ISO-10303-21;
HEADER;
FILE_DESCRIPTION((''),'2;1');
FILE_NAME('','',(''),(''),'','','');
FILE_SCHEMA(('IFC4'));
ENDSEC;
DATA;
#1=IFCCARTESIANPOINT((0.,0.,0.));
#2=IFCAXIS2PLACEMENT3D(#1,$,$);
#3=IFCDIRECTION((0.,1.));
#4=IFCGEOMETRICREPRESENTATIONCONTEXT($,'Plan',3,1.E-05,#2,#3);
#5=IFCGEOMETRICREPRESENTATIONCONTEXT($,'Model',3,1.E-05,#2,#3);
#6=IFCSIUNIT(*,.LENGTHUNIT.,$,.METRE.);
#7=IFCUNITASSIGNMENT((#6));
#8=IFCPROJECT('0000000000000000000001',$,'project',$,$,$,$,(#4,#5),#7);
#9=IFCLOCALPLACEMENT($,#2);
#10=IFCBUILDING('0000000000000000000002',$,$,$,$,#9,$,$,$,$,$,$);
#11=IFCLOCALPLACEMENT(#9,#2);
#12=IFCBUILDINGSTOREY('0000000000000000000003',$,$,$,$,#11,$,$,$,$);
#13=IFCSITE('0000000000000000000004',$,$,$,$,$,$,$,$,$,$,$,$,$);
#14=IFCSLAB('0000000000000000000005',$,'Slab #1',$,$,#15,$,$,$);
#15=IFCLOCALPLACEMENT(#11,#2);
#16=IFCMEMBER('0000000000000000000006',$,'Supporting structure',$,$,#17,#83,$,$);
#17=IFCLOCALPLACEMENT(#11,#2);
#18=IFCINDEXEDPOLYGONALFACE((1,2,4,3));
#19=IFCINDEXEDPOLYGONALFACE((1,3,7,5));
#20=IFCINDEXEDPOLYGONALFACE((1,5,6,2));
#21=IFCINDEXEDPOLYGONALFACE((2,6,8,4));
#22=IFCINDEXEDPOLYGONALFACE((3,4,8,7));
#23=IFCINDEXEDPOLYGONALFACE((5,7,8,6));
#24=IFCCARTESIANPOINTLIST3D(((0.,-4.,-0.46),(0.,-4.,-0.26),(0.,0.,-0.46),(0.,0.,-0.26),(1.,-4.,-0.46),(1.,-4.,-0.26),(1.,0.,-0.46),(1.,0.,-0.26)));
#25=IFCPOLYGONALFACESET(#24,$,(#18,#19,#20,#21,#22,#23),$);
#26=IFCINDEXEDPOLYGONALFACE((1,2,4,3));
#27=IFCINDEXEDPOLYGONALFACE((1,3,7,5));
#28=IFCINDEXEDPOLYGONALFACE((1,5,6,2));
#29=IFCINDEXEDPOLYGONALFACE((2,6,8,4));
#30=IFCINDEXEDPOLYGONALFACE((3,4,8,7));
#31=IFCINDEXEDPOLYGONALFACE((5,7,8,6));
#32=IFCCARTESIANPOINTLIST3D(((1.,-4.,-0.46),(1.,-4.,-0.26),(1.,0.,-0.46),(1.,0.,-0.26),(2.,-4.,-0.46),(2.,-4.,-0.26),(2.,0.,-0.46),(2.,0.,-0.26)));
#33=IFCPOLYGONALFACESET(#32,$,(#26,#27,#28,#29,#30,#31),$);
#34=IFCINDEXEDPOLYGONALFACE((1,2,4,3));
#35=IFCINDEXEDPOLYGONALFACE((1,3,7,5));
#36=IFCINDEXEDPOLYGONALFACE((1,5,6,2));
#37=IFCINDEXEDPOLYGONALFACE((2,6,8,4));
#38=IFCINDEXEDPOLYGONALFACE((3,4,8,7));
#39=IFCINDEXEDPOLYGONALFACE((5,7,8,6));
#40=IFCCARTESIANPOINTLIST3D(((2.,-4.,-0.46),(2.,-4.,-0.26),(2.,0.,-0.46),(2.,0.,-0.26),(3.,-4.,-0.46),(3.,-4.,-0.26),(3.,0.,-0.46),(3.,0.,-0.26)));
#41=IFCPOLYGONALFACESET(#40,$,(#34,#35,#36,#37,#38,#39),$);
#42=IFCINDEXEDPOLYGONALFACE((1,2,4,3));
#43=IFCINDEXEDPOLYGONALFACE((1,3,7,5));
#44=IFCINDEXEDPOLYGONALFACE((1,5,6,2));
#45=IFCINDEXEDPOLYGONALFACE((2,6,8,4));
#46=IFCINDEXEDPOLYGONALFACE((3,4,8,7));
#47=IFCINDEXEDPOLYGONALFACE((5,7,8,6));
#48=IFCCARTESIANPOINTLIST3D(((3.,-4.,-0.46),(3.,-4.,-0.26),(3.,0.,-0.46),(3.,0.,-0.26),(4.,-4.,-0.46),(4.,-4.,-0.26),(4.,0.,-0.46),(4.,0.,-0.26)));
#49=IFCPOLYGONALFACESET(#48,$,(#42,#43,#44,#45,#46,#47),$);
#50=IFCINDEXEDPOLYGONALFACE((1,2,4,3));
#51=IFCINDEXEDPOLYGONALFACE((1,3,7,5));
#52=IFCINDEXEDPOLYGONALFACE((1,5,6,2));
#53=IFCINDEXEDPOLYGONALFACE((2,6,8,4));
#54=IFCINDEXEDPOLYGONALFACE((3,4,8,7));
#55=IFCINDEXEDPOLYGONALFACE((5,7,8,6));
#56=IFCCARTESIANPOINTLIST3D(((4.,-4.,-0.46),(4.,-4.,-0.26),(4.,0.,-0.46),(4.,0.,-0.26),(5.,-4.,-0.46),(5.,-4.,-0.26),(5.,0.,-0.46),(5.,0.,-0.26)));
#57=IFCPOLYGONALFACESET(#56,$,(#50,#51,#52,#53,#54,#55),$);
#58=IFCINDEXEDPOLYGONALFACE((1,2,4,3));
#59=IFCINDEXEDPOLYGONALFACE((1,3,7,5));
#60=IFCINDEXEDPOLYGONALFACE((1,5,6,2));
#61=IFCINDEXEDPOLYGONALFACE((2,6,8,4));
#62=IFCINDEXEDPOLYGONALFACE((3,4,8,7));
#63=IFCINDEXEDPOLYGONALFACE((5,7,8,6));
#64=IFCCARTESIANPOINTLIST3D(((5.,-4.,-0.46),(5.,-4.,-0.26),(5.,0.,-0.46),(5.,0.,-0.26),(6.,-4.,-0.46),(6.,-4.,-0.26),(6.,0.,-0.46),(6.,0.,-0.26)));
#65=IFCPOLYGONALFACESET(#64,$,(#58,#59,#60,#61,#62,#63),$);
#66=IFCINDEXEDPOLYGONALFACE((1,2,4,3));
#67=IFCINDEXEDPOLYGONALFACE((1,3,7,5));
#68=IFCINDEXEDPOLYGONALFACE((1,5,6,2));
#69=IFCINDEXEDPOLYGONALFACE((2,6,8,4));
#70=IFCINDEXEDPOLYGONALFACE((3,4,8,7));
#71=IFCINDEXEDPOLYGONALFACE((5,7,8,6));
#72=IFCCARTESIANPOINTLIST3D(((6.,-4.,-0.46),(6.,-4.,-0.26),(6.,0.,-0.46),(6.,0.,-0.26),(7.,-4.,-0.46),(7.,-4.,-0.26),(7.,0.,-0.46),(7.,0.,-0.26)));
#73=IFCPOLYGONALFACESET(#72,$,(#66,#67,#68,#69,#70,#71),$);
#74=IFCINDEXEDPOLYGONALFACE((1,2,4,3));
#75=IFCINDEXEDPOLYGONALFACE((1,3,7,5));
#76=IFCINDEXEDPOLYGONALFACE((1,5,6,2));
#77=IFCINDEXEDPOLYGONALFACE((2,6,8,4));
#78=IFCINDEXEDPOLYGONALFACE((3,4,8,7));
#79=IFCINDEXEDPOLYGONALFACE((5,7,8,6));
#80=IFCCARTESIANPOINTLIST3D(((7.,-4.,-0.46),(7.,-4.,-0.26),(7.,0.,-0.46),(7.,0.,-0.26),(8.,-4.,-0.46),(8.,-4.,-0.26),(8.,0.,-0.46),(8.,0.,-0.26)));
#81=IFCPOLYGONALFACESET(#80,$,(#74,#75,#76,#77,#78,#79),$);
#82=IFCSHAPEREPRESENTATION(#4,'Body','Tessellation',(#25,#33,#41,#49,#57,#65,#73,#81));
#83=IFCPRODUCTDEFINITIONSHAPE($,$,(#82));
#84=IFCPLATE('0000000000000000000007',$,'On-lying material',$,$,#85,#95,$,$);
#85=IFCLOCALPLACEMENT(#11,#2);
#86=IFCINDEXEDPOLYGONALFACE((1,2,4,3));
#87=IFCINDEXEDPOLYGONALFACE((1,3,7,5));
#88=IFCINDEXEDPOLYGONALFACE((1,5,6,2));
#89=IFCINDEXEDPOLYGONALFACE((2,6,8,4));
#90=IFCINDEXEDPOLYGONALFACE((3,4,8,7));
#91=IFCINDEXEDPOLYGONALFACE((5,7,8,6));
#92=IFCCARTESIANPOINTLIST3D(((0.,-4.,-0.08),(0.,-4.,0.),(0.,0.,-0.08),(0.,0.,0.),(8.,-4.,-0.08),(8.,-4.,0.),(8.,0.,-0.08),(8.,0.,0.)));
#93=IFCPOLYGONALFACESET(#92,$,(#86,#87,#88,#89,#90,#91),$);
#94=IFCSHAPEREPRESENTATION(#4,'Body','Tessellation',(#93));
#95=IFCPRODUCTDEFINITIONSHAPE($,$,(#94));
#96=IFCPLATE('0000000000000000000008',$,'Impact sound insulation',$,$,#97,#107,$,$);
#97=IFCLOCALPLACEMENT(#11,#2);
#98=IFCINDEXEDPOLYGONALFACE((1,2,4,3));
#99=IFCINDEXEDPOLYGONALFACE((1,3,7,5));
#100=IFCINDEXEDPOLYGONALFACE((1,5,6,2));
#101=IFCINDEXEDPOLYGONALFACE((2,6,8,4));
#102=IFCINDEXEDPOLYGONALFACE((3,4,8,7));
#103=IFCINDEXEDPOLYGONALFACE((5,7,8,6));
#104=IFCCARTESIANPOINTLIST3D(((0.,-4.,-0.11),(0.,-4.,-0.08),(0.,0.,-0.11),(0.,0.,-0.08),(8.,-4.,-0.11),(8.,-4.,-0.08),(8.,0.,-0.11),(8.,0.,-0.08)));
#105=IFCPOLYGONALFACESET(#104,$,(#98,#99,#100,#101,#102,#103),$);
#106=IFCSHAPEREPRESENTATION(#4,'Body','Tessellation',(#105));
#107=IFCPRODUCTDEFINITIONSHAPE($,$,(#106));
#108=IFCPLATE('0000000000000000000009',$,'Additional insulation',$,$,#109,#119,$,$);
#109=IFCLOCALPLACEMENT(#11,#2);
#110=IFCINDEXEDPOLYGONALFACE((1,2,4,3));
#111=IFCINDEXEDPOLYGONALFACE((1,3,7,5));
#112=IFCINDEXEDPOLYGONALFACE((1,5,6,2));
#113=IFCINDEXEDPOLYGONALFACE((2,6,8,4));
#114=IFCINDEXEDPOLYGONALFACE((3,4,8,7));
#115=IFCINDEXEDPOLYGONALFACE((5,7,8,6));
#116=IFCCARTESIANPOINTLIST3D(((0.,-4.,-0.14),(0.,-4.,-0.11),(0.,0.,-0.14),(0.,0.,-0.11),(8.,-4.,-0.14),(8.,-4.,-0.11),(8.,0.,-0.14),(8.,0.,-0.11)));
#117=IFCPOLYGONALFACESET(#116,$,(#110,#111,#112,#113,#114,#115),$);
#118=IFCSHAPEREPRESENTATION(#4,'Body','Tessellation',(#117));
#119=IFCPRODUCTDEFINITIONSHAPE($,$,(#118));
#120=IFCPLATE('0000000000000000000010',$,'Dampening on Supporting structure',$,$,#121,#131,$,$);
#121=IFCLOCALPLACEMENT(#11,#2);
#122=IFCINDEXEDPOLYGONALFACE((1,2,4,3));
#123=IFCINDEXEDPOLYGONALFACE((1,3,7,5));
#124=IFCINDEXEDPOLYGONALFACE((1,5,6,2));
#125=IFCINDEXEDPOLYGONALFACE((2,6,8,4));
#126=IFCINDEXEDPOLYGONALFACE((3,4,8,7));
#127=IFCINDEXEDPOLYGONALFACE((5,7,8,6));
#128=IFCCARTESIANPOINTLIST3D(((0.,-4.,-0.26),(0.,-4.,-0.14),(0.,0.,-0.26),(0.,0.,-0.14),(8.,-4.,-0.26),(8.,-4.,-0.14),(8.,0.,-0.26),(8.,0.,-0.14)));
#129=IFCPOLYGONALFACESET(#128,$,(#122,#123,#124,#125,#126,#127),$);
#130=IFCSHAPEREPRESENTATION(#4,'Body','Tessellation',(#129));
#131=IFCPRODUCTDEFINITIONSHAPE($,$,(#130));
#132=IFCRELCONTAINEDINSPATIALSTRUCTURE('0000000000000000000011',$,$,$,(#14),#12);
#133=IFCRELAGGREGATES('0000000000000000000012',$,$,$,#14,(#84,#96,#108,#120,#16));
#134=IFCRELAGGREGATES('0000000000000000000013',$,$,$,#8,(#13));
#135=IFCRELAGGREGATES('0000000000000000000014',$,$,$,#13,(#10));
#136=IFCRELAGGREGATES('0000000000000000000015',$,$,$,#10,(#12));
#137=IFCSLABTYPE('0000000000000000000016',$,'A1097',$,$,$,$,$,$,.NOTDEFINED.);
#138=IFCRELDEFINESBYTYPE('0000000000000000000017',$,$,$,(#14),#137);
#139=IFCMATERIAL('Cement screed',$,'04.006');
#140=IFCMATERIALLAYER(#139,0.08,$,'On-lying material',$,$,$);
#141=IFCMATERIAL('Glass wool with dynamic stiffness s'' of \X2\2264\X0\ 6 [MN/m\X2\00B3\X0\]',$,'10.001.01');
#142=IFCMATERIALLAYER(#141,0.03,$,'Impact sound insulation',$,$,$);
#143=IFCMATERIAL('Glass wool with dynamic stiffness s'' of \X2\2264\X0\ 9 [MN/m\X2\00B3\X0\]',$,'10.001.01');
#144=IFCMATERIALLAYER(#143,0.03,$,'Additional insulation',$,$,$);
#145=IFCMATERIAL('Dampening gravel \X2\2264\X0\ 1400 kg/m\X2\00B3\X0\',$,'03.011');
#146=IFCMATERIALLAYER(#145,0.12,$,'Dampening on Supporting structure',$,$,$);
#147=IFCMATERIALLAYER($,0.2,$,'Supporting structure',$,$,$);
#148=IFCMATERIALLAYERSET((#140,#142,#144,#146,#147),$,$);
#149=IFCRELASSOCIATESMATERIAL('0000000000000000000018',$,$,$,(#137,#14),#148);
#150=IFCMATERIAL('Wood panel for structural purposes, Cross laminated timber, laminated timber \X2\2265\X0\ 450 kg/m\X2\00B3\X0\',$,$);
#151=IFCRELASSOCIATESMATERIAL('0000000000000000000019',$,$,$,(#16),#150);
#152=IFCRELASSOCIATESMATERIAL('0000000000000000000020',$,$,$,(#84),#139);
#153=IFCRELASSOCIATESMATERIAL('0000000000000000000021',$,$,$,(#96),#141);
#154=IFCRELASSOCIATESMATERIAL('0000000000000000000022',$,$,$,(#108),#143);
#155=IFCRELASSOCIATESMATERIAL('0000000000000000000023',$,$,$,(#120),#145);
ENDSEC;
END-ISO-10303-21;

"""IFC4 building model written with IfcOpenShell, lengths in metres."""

from ifc_helpers import new_model, si_unit, direction, frame, frame_2d, origin, origin_with_axes, place, context, project, spatial, rectangle, extrude, material, layer, layer_set, type_object, element, aggregate, save


model = new_model("IFC4")

# Units and contexts
plan_context = context("Plan", 3, precision=1e-05, world=origin(), true_north=direction((0.0, 1.0)))
model_context = context("Model", 3, precision=1e-05, world=origin(), true_north=direction((0.0, 1.0)))
ifc_project = project(units=[si_unit("LENGTHUNIT", "METRE")], contexts=[plan_context, model_context])

# Site, building, storey
site = spatial("IfcSite", under=ifc_project)
building_placement = place(None, origin())
building = spatial("IfcBuilding", under=site, at=building_placement)
storey_placement = place(building_placement, origin())
storey = spatial("IfcBuildingStorey", under=building, at=storey_placement)

# Slab, member, plates
ifc_material_1 = material(Name="Cement screed", Category="04.006")
ifc_layer_1 = layer(ifc_material_1, 0.08, Name="On-lying material")
ifc_material_2 = material(Name="Glass wool with dynamic stiffness s' of ≤ 6 [MN/m³]", Category="10.001.01")
ifc_layer_2 = layer(ifc_material_2, 0.03, Name="Impact sound insulation")
ifc_material_3 = material(Name="Glass wool with dynamic stiffness s' of ≤ 9 [MN/m³]", Category="10.001.01")
ifc_layer_3 = layer(ifc_material_3, 0.03, Name="Additional insulation")
ifc_material_4 = material(Name="Dampening gravel ≤ 1400 kg/m³", Category="03.011")
ifc_layer_4 = layer(ifc_material_4, 0.12, Name="Dampening on Supporting structure")
ifc_layer_5 = layer(None, 0.2, Name="Supporting structure")
ifc_layer_set = layer_set([ifc_layer_1, ifc_layer_2, ifc_layer_3, ifc_layer_4, ifc_layer_5])
slab_type = type_object("IfcSlabType", Name="A1097", PredefinedType="NOTDEFINED", material=ifc_layer_set)
slab_placement = place(None, frame((0.0, 0.0, 0.0), z_axis=(0.0, 0.0, -1.0), x_axis=(1.0, 0.0, 0.0)))
slab = element("IfcSlab", 1, at=slab_placement, inside=storey, type_object=slab_type, material=ifc_layer_set, Name="Slab #1")
ifc_material_5 = material(Name="Wood panel for structural purposes, Cross laminated timber, laminated timber ≥ 450 kg/m³")
member_placement = place(slab_placement, origin())
member = element("IfcMember", 2, at=member_placement, material=ifc_material_5, Name="Supporting structure", context=plan_context, shape_type="SweptSolid", body=[
    extrude(rectangle(XDim=1.0, YDim=0.2, at=frame_2d((0.5, 0.1), x_axis=(1.0, 0.0))), frame((0.0, 4.0, 0.26), z_axis=(0.0, -1.0, 0.0), x_axis=(1.0, 0.0, 0.0)), (0.0, 0.0, 1.0), 4.0),
    extrude(rectangle(XDim=1.0, YDim=0.2, at=frame_2d((0.5, 0.1), x_axis=(1.0, 0.0))), frame((1.0, 4.0, 0.26), z_axis=(0.0, -1.0, 0.0), x_axis=(1.0, 0.0, 0.0)), (0.0, 0.0, 1.0), 4.0),
    extrude(rectangle(XDim=1.0, YDim=0.2, at=frame_2d((0.5, 0.1), x_axis=(1.0, 0.0))), frame((2.0, 4.0, 0.26), z_axis=(0.0, -1.0, 0.0), x_axis=(1.0, 0.0, 0.0)), (0.0, 0.0, 1.0), 4.0),
    extrude(rectangle(XDim=1.0, YDim=0.2, at=frame_2d((0.5, 0.1), x_axis=(1.0, 0.0))), frame((3.0, 4.0, 0.26), z_axis=(0.0, -1.0, 0.0), x_axis=(1.0, 0.0, 0.0)), (0.0, 0.0, 1.0), 4.0),
    extrude(rectangle(XDim=1.0, YDim=0.2, at=frame_2d((0.5, 0.1), x_axis=(1.0, 0.0))), frame((4.0, 4.0, 0.26), z_axis=(0.0, -1.0, 0.0), x_axis=(1.0, 0.0, 0.0)), (0.0, 0.0, 1.0), 4.0),
    extrude(rectangle(XDim=1.0, YDim=0.2, at=frame_2d((0.5, 0.1), x_axis=(1.0, 0.0))), frame((5.0, 4.0, 0.26), z_axis=(0.0, -1.0, 0.0), x_axis=(1.0, 0.0, 0.0)), (0.0, 0.0, 1.0), 4.0),
    extrude(rectangle(XDim=1.0, YDim=0.2, at=frame_2d((0.5, 0.1), x_axis=(1.0, 0.0))), frame((6.0, 4.0, 0.26), z_axis=(0.0, -1.0, 0.0), x_axis=(1.0, 0.0, 0.0)), (0.0, 0.0, 1.0), 4.0),
    extrude(rectangle(XDim=1.0, YDim=0.2, at=frame_2d((0.5, 0.1), x_axis=(1.0, 0.0))), frame((7.0, 4.0, 0.26), z_axis=(0.0, -1.0, 0.0), x_axis=(1.0, 0.0, 0.0)), (0.0, 0.0, 1.0), 4.0),
])
plate_1_placement = place(slab_placement, origin())
plate_1 = element("IfcPlate", 3, at=plate_1_placement, material=ifc_material_1, Name="On-lying material", context=plan_context, shape_type="SweptSolid", body=[
    extrude(rectangle(XDim=8.0, YDim=4.0, at=frame_2d((4.0, 2.0), x_axis=(1.0, 0.0))), origin_with_axes(), (0.0, 0.0, 1.0), 0.08),
])
plate_2_placement = place(slab_placement, origin())
plate_2 = element("IfcPlate", 4, at=plate_2_placement, material=ifc_material_2, Name="Impact sound insulation", context=plan_context, shape_type="SweptSolid", body=[
    extrude(rectangle(XDim=8.0, YDim=4.0, at=frame_2d((4.0, 2.0), x_axis=(1.0, 0.0))), frame((0.0, 0.0, 0.08), z_axis=(0.0, 0.0, 1.0), x_axis=(1.0, 0.0, 0.0)), (0.0, 0.0, 1.0), 0.03),
])
plate_3_placement = place(slab_placement, origin())
plate_3 = element("IfcPlate", 5, at=plate_3_placement, material=ifc_material_3, Name="Additional insulation", context=plan_context, shape_type="SweptSolid", body=[
    extrude(rectangle(XDim=8.0, YDim=4.0, at=frame_2d((4.0, 2.0), x_axis=(1.0, 0.0))), frame((0.0, 0.0, 0.11), z_axis=(0.0, 0.0, 1.0), x_axis=(1.0, 0.0, 0.0)), (0.0, 0.0, 1.0), 0.03),
])
plate_4_placement = place(slab_placement, origin())
plate_4 = element("IfcPlate", 6, at=plate_4_placement, material=ifc_material_4, Name="Dampening on Supporting structure", context=plan_context, shape_type="SweptSolid", body=[
    extrude(rectangle(XDim=8.0, YDim=4.0, at=frame_2d((4.0, 2.0), x_axis=(1.0, 0.0))), frame((0.0, 0.0, 0.14), z_axis=(0.0, 0.0, 1.0), x_axis=(1.0, 0.0, 0.0)), (0.0, 0.0, 1.0), 0.12),
])
aggregate(slab, [plate_1, plate_2, plate_3, plate_4, member])

save(model, "model.ifc")
